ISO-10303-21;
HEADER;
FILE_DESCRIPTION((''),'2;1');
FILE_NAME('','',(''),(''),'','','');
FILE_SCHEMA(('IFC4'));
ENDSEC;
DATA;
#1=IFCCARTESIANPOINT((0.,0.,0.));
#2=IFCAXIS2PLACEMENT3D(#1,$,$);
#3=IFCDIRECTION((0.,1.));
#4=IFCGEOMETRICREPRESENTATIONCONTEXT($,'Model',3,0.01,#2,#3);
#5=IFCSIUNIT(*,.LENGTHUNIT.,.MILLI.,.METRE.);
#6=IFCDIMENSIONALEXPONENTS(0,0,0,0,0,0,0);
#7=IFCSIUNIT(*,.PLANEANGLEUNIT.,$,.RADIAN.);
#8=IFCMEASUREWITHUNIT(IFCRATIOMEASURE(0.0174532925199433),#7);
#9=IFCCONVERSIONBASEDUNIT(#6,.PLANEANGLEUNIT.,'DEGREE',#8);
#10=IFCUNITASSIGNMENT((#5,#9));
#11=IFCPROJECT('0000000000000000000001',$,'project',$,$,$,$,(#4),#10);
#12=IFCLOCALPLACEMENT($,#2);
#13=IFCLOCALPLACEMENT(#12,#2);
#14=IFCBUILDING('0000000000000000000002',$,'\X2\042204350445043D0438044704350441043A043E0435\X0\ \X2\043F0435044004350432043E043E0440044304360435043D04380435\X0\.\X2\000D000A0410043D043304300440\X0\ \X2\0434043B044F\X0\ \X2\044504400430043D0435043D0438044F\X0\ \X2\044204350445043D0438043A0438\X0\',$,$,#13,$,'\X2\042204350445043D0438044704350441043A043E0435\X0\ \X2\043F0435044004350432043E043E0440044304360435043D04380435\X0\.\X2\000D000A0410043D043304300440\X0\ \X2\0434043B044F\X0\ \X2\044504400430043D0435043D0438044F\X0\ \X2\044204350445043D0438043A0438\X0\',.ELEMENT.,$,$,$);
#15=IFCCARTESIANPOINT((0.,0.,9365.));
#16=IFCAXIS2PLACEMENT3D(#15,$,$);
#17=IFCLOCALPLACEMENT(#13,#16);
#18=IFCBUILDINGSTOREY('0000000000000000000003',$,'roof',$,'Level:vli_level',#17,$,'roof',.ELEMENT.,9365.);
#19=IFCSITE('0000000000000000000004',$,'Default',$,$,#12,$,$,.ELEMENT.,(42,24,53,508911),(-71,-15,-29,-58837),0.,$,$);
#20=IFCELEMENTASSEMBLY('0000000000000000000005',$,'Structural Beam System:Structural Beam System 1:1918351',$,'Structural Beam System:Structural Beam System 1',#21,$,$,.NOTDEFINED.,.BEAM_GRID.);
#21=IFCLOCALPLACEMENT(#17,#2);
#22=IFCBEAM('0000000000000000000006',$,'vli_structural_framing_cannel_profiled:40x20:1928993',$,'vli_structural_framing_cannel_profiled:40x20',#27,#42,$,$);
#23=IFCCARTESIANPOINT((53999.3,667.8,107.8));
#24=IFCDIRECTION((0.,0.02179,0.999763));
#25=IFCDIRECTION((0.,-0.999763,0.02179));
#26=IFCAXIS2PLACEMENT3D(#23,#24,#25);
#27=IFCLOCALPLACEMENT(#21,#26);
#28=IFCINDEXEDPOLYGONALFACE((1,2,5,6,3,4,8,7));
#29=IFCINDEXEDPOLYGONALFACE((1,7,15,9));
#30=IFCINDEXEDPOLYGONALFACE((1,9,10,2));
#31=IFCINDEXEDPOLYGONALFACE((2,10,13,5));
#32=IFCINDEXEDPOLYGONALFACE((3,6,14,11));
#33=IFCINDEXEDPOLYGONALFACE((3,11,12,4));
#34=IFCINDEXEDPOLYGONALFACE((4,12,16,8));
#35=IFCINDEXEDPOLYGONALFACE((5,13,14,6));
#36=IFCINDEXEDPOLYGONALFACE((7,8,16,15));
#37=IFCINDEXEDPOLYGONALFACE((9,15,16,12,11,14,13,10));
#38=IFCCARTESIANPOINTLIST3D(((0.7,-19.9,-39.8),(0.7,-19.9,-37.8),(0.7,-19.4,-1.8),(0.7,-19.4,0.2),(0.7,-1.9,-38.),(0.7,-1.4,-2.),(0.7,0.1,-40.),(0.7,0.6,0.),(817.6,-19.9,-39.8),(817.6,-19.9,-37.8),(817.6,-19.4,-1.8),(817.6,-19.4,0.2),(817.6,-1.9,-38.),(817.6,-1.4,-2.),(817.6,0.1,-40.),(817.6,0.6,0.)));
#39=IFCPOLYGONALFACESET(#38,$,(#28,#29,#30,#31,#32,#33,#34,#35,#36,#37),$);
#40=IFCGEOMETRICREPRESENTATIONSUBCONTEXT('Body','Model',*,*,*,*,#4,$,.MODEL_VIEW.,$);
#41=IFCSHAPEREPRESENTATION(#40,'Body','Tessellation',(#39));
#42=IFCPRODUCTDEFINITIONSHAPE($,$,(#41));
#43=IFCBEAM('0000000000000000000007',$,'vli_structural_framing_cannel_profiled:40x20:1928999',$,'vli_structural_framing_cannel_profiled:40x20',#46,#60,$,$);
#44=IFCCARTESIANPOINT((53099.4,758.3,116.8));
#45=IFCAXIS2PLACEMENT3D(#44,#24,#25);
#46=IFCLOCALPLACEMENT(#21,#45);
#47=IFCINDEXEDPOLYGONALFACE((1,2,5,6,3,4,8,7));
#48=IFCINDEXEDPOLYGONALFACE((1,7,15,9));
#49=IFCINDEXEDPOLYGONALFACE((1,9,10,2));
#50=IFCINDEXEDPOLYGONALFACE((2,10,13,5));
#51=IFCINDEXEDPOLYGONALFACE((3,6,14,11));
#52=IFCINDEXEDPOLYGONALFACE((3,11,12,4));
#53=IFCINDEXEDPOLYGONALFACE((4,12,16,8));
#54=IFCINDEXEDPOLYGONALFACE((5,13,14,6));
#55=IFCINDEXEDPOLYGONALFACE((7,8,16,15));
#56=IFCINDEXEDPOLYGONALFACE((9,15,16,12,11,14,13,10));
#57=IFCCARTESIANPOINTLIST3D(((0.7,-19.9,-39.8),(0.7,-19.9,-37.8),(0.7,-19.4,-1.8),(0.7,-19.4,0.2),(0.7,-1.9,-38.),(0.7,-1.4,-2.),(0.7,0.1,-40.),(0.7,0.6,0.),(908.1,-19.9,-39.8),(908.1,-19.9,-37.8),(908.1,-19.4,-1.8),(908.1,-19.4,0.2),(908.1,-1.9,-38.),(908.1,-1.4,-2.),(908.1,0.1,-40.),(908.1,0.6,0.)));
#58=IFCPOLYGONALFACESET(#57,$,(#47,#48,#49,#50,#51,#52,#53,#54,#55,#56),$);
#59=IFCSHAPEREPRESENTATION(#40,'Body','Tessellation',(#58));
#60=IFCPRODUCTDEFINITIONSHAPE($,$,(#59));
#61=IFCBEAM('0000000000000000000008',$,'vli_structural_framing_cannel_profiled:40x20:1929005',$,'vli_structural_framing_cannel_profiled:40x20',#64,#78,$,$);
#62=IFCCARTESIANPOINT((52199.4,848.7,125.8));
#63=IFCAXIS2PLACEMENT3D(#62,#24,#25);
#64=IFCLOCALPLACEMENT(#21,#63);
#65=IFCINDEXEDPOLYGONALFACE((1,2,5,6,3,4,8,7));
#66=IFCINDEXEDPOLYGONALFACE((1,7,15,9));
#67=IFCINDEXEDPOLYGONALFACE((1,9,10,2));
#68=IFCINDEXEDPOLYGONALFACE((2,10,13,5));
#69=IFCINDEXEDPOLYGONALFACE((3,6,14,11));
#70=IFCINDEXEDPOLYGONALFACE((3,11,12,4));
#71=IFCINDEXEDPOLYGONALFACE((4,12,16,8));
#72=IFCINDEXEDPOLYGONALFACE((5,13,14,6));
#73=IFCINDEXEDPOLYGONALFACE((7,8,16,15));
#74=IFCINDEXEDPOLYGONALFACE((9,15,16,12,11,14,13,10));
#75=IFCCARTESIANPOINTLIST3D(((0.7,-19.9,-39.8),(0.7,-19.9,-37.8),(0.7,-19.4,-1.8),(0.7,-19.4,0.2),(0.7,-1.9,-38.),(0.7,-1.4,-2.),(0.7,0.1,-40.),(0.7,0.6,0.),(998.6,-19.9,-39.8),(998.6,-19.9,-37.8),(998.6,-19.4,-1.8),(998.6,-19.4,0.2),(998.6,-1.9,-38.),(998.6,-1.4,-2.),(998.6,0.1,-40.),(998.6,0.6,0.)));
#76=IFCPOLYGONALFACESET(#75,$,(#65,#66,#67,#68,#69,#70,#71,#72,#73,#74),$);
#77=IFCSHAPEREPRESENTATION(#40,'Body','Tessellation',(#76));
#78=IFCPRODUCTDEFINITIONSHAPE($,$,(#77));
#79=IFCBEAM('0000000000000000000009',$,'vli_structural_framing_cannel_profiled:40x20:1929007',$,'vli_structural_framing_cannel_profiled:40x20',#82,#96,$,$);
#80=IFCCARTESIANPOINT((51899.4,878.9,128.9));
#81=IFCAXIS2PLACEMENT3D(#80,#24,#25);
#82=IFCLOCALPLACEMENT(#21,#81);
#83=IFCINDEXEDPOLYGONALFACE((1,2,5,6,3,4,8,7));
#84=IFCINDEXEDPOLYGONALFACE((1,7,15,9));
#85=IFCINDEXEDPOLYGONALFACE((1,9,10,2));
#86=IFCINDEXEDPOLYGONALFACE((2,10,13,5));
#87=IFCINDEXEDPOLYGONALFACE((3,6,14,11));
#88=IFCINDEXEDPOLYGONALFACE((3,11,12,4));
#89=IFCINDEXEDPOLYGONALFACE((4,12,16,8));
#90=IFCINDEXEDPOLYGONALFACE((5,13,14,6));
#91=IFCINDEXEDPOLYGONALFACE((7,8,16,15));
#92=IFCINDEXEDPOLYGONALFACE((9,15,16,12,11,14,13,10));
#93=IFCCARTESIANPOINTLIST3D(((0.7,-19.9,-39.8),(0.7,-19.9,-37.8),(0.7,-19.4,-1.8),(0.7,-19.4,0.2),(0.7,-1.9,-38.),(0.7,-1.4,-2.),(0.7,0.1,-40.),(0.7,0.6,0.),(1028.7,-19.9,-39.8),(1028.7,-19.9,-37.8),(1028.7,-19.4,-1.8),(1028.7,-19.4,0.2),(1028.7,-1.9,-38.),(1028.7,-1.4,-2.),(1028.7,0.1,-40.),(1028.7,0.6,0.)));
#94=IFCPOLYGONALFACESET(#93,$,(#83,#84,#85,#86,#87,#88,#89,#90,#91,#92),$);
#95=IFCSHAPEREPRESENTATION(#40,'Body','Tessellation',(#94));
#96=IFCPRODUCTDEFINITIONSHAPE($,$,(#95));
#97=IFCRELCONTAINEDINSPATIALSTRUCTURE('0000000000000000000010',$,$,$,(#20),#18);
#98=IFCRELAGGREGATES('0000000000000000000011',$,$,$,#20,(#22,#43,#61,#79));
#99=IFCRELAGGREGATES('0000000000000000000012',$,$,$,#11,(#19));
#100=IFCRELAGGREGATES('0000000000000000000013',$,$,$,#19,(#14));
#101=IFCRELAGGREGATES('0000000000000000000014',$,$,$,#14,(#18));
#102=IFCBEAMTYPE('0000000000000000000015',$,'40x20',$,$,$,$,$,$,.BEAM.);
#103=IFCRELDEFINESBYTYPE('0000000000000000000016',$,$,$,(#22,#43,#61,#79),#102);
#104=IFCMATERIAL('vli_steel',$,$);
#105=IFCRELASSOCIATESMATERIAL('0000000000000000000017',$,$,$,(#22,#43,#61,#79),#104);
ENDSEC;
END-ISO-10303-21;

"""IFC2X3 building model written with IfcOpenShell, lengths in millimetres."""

from ifc_helpers import new_model, entity, si_unit, converted_unit, direction, frame, origin, place, context, subcontext, project, spatial, polyline, outline, extrude, material, type_object, element, aggregate, save


model = new_model("IFC2X3")

# Units and contexts
model_context = context("Model", 3, precision=0.01, world=origin(), true_north=direction((0.0, 1.0)))
body_context = subcontext(model_context, "Body", "Model", "MODEL_VIEW")
ifc_project = project(units=[si_unit("LENGTHUNIT", "METRE", prefix="MILLI"), converted_unit("PLANEANGLEUNIT", "DEGREE", entity("IfcRatioMeasure", 0.0174532925199433), si_unit("PLANEANGLEUNIT", "RADIAN"), dimensions=[0, 0, 0, 0, 0, 0, 0])], contexts=[model_context])

# Site, building, storey
site_placement = place(None, origin())
site = spatial("IfcSite", under=ifc_project, at=site_placement, Name="Default", CompositionType="ELEMENT", RefLatitude=(42, 24, 53, 508911), RefLongitude=(-71, -15, -29, -58837), RefElevation=0.0)
building_placement = place(site_placement, origin())
building = spatial("IfcBuilding", under=site, at=building_placement, Name="Техническое перевооружение.\r\nАнгар для хранения техники", LongName="Техническое перевооружение.\r\nАнгар для хранения техники", CompositionType="ELEMENT")
storey_placement = place(building_placement, frame((0.0, 0.0, 9365.0)))
storey = spatial("IfcBuildingStorey", under=building, at=storey_placement, Name="roof", ObjectType="Level:vli_level", LongName="roof", CompositionType="ELEMENT", Elevation=9365.0)

# Element assembly, beams
ifc_material = material(Name="vli_steel")
beam_type = type_object("IfcBeamType", Name="40x20", PredefinedType="BEAM")
assembly_1_placement = place(storey_placement, origin())
assembly_1 = element("IfcElementAssembly", 1, at=assembly_1_placement, inside=storey, Name="Structural Beam System:Structural Beam System 1:1918351", ObjectType="Structural Beam System:Structural Beam System 1", AssemblyPlace="NOTDEFINED", PredefinedType="BEAM_GRID")
beam_1_placement = place(assembly_1_placement, frame((53999.3, 667.8, 107.8), z_axis=(0.0, 0.02179, 0.999763), x_axis=(0.0, -0.999763, 0.02179)))
beam_1 = element("IfcBeam", 2, at=beam_1_placement, type_object=beam_type, material=ifc_material, Name="vli_structural_framing_cannel_profiled:40x20:1928993", ObjectType="vli_structural_framing_cannel_profiled:40x20", context=body_context, shape_type="SweptSolid", body=[
    extrude(outline(polyline([(-10.5, -20.0), (9.5, -20.0), (9.5, -18.0), (-8.5, -18.0), (-8.5, 18.0), (9.5, 18.0), (9.5, 20.0), (-10.5, 20.0), (-10.5, -20.0)])), frame((0.7, -10.1, -19.9), z_axis=(1.0, 0.0, 0.0), x_axis=(0.0, -0.999925, 0.012243)), (0.0, 0.0, 1.0), 816.9),
])
beam_2_placement = place(assembly_1_placement, frame((53099.4, 758.3, 116.8), z_axis=(0.0, 0.02179, 0.999763), x_axis=(0.0, -0.999763, 0.02179)))
beam_2 = element("IfcBeam", 3, at=beam_2_placement, type_object=beam_type, material=ifc_material, Name="vli_structural_framing_cannel_profiled:40x20:1928999", ObjectType="vli_structural_framing_cannel_profiled:40x20", context=body_context, shape_type="SweptSolid", body=[
    extrude(outline(polyline([(-10.5, -20.0), (9.5, -20.0), (9.5, -18.0), (-8.5, -18.0), (-8.5, 18.0), (9.5, 18.0), (9.5, 20.0), (-10.5, 20.0), (-10.5, -20.0)])), frame((0.7, -10.1, -19.9), z_axis=(1.0, 0.0, 0.0), x_axis=(0.0, -0.999925, 0.012243)), (0.0, 0.0, 1.0), 907.4),
])
beam_3_placement = place(assembly_1_placement, frame((52199.4, 848.7, 125.8), z_axis=(0.0, 0.02179, 0.999763), x_axis=(0.0, -0.999763, 0.02179)))
beam_3 = element("IfcBeam", 4, at=beam_3_placement, type_object=beam_type, material=ifc_material, Name="vli_structural_framing_cannel_profiled:40x20:1929005", ObjectType="vli_structural_framing_cannel_profiled:40x20", context=body_context, shape_type="SweptSolid", body=[
    extrude(outline(polyline([(-10.5, -20.0), (9.5, -20.0), (9.5, -18.0), (-8.5, -18.0), (-8.5, 18.0), (9.5, 18.0), (9.5, 20.0), (-10.5, 20.0), (-10.5, -20.0)])), frame((0.7, -10.1, -19.9), z_axis=(1.0, 0.0, 0.0), x_axis=(0.0, -0.999925, 0.012243)), (0.0, 0.0, 1.0), 997.9),
])
beam_4_placement = place(assembly_1_placement, frame((51899.4, 878.9, 128.9), z_axis=(0.0, 0.02179, 0.999763), x_axis=(0.0, -0.999763, 0.02179)))
beam_4 = element("IfcBeam", 5, at=beam_4_placement, type_object=beam_type, material=ifc_material, Name="vli_structural_framing_cannel_profiled:40x20:1929007", ObjectType="vli_structural_framing_cannel_profiled:40x20", context=body_context, shape_type="SweptSolid", body=[
    extrude(outline(polyline([(-10.5, -20.0), (9.5, -20.0), (9.5, -18.0), (-8.5, -18.0), (-8.5, 18.0), (9.5, 18.0), (9.5, 20.0), (-10.5, 20.0), (-10.5, -20.0)])), frame((0.7, -10.1, -19.9), z_axis=(1.0, 0.0, 0.0), x_axis=(0.0, -0.999925, 0.012243)), (0.0, 0.0, 1.0), 1028.0),
])
aggregate(assembly_1, [beam_1, beam_2, beam_3, beam_4])

save(model, "model.ifc")
